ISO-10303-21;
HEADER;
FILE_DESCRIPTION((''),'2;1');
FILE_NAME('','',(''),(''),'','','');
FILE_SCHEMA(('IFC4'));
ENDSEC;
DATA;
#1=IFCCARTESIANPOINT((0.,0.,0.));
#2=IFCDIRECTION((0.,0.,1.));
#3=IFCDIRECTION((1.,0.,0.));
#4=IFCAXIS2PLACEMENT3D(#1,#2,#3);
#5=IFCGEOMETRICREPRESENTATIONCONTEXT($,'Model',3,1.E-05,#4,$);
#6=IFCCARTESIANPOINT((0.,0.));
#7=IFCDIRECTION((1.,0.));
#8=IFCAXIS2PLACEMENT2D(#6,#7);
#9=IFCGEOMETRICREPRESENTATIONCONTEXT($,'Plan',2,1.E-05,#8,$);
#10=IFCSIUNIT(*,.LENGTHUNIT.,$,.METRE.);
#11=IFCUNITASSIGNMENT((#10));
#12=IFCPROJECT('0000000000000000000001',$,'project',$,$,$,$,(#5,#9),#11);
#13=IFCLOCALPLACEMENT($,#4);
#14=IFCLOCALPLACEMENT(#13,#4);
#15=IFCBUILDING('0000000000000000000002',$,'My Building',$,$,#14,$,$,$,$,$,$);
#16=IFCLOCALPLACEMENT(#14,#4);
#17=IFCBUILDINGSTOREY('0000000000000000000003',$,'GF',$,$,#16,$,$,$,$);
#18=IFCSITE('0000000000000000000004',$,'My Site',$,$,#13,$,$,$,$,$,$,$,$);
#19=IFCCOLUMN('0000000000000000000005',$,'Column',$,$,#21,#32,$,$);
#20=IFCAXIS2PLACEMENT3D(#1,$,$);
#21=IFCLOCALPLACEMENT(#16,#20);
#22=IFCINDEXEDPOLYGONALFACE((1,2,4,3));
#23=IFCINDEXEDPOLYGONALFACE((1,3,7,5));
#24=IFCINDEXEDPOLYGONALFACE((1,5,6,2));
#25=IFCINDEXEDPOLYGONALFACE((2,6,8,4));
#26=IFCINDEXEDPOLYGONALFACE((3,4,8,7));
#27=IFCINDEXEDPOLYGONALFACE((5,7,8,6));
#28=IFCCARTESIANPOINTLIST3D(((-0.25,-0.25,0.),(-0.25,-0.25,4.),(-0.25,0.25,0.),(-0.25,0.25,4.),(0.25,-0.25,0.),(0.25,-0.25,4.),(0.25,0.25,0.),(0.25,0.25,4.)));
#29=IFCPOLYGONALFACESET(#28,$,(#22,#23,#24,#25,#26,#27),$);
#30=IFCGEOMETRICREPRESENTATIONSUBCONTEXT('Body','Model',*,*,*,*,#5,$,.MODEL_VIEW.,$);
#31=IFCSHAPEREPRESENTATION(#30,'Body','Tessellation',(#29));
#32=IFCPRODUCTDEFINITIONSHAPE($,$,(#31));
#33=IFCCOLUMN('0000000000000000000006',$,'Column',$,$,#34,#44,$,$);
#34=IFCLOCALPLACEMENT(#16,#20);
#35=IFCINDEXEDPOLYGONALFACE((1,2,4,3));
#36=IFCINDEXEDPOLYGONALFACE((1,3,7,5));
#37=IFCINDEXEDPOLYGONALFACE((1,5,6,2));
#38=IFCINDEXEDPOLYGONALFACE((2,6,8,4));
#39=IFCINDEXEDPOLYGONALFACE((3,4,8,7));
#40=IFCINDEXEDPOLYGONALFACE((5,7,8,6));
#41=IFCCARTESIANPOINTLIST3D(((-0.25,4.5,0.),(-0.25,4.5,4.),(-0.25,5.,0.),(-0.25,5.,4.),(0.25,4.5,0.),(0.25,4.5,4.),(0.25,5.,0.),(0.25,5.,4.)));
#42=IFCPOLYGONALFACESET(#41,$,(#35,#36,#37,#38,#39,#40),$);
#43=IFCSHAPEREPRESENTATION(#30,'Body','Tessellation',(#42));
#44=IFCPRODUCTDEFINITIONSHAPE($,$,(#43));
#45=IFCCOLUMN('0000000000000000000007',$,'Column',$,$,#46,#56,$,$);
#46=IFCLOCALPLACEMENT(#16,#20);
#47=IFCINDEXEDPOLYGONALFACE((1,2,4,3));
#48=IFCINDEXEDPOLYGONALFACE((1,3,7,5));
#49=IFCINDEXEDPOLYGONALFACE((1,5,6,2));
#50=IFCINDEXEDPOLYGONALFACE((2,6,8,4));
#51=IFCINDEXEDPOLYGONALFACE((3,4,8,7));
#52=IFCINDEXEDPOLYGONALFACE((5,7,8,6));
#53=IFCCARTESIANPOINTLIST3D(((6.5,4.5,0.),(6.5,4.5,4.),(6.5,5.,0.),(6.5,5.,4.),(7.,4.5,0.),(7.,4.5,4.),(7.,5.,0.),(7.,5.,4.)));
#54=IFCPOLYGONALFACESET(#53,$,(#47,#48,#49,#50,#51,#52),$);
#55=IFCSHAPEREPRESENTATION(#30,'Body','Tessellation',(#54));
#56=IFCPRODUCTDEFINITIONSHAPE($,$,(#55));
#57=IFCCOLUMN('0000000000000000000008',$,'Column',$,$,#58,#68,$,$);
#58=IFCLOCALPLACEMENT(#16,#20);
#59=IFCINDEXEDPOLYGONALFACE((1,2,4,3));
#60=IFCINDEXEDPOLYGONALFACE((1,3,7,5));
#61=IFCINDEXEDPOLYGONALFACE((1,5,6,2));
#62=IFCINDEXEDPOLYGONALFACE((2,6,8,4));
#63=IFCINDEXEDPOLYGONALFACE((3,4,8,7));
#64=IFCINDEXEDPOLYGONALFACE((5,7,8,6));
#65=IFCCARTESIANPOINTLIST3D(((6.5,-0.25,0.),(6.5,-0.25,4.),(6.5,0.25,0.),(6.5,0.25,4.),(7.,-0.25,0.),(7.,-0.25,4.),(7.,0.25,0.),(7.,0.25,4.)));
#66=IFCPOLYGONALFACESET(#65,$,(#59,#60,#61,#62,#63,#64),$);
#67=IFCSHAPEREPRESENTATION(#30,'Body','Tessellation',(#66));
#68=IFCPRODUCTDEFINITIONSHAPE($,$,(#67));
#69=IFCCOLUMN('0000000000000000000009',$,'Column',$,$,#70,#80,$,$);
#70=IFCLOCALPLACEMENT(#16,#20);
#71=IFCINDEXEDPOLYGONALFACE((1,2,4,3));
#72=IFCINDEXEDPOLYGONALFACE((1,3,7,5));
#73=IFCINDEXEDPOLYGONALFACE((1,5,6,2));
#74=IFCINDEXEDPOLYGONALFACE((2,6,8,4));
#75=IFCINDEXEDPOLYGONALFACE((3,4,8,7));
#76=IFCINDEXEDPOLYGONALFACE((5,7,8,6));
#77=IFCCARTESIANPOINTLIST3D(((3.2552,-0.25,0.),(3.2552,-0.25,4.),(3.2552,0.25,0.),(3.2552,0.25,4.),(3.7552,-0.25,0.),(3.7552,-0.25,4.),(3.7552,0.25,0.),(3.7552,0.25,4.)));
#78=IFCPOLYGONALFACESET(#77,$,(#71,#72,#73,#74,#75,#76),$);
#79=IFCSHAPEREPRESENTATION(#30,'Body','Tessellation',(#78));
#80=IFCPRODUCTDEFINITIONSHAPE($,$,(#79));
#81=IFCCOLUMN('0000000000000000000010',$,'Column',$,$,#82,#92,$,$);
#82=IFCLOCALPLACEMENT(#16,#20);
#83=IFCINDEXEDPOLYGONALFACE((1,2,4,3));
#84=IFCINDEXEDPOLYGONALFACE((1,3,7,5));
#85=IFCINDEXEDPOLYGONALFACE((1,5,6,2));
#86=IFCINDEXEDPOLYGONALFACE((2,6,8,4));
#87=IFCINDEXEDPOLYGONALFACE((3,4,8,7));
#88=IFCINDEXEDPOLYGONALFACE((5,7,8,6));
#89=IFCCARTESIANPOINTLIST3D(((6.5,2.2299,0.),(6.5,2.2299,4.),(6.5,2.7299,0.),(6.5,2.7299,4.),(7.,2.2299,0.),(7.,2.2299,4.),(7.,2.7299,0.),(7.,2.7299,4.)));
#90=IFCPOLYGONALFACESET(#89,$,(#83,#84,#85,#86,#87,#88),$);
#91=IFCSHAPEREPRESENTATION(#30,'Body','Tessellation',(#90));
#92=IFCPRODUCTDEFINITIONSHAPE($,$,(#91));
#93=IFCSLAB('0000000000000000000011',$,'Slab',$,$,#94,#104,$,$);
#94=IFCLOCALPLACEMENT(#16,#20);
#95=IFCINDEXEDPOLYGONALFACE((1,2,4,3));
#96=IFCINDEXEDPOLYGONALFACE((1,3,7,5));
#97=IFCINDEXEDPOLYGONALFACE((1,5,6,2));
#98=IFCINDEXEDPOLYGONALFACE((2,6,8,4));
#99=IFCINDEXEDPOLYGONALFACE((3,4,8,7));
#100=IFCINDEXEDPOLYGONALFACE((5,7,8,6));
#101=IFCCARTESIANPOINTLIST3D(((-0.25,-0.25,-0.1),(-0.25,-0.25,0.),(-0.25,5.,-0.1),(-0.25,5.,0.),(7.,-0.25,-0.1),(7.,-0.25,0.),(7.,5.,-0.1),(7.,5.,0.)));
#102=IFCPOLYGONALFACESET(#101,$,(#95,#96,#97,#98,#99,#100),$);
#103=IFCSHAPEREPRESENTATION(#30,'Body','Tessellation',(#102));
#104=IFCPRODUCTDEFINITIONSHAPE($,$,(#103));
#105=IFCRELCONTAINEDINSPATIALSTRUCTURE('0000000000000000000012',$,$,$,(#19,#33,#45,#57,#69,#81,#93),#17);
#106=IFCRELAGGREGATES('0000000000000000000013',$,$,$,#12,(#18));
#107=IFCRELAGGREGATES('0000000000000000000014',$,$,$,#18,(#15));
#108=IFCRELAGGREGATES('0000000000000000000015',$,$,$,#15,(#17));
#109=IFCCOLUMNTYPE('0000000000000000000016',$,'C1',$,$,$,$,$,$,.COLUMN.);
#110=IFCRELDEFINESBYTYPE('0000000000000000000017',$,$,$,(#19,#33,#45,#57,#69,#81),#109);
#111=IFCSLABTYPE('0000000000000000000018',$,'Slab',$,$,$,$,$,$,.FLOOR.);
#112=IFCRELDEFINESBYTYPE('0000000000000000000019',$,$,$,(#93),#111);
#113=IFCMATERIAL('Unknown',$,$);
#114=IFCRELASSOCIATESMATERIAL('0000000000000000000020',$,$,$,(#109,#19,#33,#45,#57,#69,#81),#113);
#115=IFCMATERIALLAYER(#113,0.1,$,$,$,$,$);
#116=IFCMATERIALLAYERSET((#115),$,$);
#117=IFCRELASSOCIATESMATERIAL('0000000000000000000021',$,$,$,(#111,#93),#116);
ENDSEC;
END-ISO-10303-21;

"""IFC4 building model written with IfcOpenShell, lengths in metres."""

from ifc_helpers import new_model, si_unit, frame, origin_with_axes, origin_2d_with_axis, place, context, subcontext, project, spatial, indexed_curve, rectangle, outline, extrude, material, layer, layer_set, layer_usage, material_profile, profile_set, profile_usage, type_object, element, save


model = new_model("IFC4")

# Units and contexts
model_context = context("Model", 3, precision=1e-05, world=origin_with_axes())
plan_context = context("Plan", 2, precision=1e-05, world=origin_2d_with_axis())
body_context_1 = subcontext(model_context, "Body", "Model", "MODEL_VIEW")
ifc_project = project(units=[si_unit("LENGTHUNIT", "METRE")], contexts=[model_context, plan_context])

# Site, building, storey
site_placement = place(None, origin_with_axes())
site = spatial("IfcSite", under=ifc_project, at=site_placement, Name="My Site")
building_placement = place(site_placement, origin_with_axes())
building = spatial("IfcBuilding", under=site, at=building_placement, Name="My Building")
storey_placement = place(building_placement, origin_with_axes())
storey = spatial("IfcBuildingStorey", under=building, at=storey_placement, Name="GF")

# Columns
ifc_material = material(Name="Unknown")
ifc_material_profile = material_profile(ifc_material, rectangle(XDim=0.5, YDim=0.5))
ifc_profile_set = profile_set([ifc_material_profile])
ifc_profile_usage_1 = profile_usage(ifc_profile_set, cardinal=5)
column_type = type_object("IfcColumnType", Name="C1", PredefinedType="COLUMN", material=ifc_profile_set)
column_1_placement = place(storey_placement, origin_with_axes())
element("IfcColumn", 1, at=column_1_placement, inside=storey, type_object=column_type, material=ifc_profile_usage_1, Name="Column", context=body_context_1, shape_type="SweptSolid", body=[
    extrude(rectangle(XDim=0.5, YDim=0.5), origin_with_axes(), (0.0, 0.0, 1.0), 4.0),
])
ifc_profile_usage_2 = profile_usage(ifc_profile_set, cardinal=5)
column_2_placement = place(storey_placement, frame((0.0, 4.75, 0.0), z_axis=(0.0, 0.0, 1.0), x_axis=(1.0, 0.0, 0.0)))
element("IfcColumn", 2, at=column_2_placement, inside=storey, type_object=column_type, material=ifc_profile_usage_2, Name="Column", context=body_context_1, shape_type="SweptSolid", body=[
    extrude(rectangle(XDim=0.5, YDim=0.5), origin_with_axes(), (0.0, 0.0, 1.0), 4.0),
])
ifc_profile_usage_3 = profile_usage(ifc_profile_set, cardinal=5)
column_3_placement = place(storey_placement, frame((6.75, 4.75, 0.0), z_axis=(0.0, 0.0, 1.0), x_axis=(1.0, 0.0, 0.0)))
element("IfcColumn", 3, at=column_3_placement, inside=storey, type_object=column_type, material=ifc_profile_usage_3, Name="Column", context=body_context_1, shape_type="SweptSolid", body=[
    extrude(rectangle(XDim=0.5, YDim=0.5), origin_with_axes(), (0.0, 0.0, 1.0), 4.0),
])
ifc_profile_usage_4 = profile_usage(ifc_profile_set, cardinal=5)
column_4_placement = place(storey_placement, frame((6.75, 0.0, 0.0), z_axis=(0.0, 0.0, 1.0), x_axis=(1.0, 0.0, 0.0)))
element("IfcColumn", 4, at=column_4_placement, inside=storey, type_object=column_type, material=ifc_profile_usage_4, Name="Column", context=body_context_1, shape_type="SweptSolid", body=[
    extrude(rectangle(XDim=0.5, YDim=0.5), origin_with_axes(), (0.0, 0.0, 1.0), 4.0),
])
ifc_profile_usage_5 = profile_usage(ifc_profile_set, cardinal=5)
column_5_placement = place(storey_placement, frame((3.5052, 0.0, 0.0), z_axis=(0.0, 0.0, 1.0), x_axis=(1.0, 0.0, 0.0)))
element("IfcColumn", 5, at=column_5_placement, inside=storey, type_object=column_type, material=ifc_profile_usage_5, Name="Column", context=body_context_1, shape_type="SweptSolid", body=[
    extrude(rectangle(XDim=0.5, YDim=0.5), origin_with_axes(), (0.0, 0.0, 1.0), 4.0),
])
ifc_profile_usage_6 = profile_usage(ifc_profile_set, cardinal=5)
column_6_placement = place(storey_placement, frame((6.75, 2.4799, 0.0), z_axis=(0.0, 0.0, 1.0), x_axis=(1.0, 0.0, 0.0)))
element("IfcColumn", 6, at=column_6_placement, inside=storey, type_object=column_type, material=ifc_profile_usage_6, Name="Column", context=body_context_1, shape_type="SweptSolid", body=[
    extrude(rectangle(XDim=0.5, YDim=0.5), origin_with_axes(), (0.0, 0.0, 1.0), 4.0),
])

# Slab
ifc_layer_1 = layer(ifc_material, 0.1)
ifc_layer_set_1 = layer_set([ifc_layer_1])
ifc_layer_usage_1 = layer_usage(ifc_layer_set_1, "AXIS3", "POSITIVE", -0.1)
slab_type = type_object("IfcSlabType", Name="Slab", PredefinedType="FLOOR", material=ifc_layer_set_1)
slab_placement = place(storey_placement, frame((-0.25, -0.25, 0.0), z_axis=(0.0, 0.0, 1.0), x_axis=(1.0, 0.0, 0.0)))
element("IfcSlab", 7, at=slab_placement, inside=storey, type_object=slab_type, material=ifc_layer_usage_1, Name="Slab", context=body_context_1, shape_type="SweptSolid", body=[
    extrude(outline(indexed_curve([(0.0, 0.0), (7.25, 0.0), (7.25, 5.25), (0.0, 5.25), (0.0, 0.0)])), frame((0.0, 0.0, -0.1), z_axis=(0.0, 0.0, 1.0), x_axis=(1.0, 0.0, 0.0)), (0.0, 0.0, 1.0), 0.1),
])

save(model, "model.ifc")
